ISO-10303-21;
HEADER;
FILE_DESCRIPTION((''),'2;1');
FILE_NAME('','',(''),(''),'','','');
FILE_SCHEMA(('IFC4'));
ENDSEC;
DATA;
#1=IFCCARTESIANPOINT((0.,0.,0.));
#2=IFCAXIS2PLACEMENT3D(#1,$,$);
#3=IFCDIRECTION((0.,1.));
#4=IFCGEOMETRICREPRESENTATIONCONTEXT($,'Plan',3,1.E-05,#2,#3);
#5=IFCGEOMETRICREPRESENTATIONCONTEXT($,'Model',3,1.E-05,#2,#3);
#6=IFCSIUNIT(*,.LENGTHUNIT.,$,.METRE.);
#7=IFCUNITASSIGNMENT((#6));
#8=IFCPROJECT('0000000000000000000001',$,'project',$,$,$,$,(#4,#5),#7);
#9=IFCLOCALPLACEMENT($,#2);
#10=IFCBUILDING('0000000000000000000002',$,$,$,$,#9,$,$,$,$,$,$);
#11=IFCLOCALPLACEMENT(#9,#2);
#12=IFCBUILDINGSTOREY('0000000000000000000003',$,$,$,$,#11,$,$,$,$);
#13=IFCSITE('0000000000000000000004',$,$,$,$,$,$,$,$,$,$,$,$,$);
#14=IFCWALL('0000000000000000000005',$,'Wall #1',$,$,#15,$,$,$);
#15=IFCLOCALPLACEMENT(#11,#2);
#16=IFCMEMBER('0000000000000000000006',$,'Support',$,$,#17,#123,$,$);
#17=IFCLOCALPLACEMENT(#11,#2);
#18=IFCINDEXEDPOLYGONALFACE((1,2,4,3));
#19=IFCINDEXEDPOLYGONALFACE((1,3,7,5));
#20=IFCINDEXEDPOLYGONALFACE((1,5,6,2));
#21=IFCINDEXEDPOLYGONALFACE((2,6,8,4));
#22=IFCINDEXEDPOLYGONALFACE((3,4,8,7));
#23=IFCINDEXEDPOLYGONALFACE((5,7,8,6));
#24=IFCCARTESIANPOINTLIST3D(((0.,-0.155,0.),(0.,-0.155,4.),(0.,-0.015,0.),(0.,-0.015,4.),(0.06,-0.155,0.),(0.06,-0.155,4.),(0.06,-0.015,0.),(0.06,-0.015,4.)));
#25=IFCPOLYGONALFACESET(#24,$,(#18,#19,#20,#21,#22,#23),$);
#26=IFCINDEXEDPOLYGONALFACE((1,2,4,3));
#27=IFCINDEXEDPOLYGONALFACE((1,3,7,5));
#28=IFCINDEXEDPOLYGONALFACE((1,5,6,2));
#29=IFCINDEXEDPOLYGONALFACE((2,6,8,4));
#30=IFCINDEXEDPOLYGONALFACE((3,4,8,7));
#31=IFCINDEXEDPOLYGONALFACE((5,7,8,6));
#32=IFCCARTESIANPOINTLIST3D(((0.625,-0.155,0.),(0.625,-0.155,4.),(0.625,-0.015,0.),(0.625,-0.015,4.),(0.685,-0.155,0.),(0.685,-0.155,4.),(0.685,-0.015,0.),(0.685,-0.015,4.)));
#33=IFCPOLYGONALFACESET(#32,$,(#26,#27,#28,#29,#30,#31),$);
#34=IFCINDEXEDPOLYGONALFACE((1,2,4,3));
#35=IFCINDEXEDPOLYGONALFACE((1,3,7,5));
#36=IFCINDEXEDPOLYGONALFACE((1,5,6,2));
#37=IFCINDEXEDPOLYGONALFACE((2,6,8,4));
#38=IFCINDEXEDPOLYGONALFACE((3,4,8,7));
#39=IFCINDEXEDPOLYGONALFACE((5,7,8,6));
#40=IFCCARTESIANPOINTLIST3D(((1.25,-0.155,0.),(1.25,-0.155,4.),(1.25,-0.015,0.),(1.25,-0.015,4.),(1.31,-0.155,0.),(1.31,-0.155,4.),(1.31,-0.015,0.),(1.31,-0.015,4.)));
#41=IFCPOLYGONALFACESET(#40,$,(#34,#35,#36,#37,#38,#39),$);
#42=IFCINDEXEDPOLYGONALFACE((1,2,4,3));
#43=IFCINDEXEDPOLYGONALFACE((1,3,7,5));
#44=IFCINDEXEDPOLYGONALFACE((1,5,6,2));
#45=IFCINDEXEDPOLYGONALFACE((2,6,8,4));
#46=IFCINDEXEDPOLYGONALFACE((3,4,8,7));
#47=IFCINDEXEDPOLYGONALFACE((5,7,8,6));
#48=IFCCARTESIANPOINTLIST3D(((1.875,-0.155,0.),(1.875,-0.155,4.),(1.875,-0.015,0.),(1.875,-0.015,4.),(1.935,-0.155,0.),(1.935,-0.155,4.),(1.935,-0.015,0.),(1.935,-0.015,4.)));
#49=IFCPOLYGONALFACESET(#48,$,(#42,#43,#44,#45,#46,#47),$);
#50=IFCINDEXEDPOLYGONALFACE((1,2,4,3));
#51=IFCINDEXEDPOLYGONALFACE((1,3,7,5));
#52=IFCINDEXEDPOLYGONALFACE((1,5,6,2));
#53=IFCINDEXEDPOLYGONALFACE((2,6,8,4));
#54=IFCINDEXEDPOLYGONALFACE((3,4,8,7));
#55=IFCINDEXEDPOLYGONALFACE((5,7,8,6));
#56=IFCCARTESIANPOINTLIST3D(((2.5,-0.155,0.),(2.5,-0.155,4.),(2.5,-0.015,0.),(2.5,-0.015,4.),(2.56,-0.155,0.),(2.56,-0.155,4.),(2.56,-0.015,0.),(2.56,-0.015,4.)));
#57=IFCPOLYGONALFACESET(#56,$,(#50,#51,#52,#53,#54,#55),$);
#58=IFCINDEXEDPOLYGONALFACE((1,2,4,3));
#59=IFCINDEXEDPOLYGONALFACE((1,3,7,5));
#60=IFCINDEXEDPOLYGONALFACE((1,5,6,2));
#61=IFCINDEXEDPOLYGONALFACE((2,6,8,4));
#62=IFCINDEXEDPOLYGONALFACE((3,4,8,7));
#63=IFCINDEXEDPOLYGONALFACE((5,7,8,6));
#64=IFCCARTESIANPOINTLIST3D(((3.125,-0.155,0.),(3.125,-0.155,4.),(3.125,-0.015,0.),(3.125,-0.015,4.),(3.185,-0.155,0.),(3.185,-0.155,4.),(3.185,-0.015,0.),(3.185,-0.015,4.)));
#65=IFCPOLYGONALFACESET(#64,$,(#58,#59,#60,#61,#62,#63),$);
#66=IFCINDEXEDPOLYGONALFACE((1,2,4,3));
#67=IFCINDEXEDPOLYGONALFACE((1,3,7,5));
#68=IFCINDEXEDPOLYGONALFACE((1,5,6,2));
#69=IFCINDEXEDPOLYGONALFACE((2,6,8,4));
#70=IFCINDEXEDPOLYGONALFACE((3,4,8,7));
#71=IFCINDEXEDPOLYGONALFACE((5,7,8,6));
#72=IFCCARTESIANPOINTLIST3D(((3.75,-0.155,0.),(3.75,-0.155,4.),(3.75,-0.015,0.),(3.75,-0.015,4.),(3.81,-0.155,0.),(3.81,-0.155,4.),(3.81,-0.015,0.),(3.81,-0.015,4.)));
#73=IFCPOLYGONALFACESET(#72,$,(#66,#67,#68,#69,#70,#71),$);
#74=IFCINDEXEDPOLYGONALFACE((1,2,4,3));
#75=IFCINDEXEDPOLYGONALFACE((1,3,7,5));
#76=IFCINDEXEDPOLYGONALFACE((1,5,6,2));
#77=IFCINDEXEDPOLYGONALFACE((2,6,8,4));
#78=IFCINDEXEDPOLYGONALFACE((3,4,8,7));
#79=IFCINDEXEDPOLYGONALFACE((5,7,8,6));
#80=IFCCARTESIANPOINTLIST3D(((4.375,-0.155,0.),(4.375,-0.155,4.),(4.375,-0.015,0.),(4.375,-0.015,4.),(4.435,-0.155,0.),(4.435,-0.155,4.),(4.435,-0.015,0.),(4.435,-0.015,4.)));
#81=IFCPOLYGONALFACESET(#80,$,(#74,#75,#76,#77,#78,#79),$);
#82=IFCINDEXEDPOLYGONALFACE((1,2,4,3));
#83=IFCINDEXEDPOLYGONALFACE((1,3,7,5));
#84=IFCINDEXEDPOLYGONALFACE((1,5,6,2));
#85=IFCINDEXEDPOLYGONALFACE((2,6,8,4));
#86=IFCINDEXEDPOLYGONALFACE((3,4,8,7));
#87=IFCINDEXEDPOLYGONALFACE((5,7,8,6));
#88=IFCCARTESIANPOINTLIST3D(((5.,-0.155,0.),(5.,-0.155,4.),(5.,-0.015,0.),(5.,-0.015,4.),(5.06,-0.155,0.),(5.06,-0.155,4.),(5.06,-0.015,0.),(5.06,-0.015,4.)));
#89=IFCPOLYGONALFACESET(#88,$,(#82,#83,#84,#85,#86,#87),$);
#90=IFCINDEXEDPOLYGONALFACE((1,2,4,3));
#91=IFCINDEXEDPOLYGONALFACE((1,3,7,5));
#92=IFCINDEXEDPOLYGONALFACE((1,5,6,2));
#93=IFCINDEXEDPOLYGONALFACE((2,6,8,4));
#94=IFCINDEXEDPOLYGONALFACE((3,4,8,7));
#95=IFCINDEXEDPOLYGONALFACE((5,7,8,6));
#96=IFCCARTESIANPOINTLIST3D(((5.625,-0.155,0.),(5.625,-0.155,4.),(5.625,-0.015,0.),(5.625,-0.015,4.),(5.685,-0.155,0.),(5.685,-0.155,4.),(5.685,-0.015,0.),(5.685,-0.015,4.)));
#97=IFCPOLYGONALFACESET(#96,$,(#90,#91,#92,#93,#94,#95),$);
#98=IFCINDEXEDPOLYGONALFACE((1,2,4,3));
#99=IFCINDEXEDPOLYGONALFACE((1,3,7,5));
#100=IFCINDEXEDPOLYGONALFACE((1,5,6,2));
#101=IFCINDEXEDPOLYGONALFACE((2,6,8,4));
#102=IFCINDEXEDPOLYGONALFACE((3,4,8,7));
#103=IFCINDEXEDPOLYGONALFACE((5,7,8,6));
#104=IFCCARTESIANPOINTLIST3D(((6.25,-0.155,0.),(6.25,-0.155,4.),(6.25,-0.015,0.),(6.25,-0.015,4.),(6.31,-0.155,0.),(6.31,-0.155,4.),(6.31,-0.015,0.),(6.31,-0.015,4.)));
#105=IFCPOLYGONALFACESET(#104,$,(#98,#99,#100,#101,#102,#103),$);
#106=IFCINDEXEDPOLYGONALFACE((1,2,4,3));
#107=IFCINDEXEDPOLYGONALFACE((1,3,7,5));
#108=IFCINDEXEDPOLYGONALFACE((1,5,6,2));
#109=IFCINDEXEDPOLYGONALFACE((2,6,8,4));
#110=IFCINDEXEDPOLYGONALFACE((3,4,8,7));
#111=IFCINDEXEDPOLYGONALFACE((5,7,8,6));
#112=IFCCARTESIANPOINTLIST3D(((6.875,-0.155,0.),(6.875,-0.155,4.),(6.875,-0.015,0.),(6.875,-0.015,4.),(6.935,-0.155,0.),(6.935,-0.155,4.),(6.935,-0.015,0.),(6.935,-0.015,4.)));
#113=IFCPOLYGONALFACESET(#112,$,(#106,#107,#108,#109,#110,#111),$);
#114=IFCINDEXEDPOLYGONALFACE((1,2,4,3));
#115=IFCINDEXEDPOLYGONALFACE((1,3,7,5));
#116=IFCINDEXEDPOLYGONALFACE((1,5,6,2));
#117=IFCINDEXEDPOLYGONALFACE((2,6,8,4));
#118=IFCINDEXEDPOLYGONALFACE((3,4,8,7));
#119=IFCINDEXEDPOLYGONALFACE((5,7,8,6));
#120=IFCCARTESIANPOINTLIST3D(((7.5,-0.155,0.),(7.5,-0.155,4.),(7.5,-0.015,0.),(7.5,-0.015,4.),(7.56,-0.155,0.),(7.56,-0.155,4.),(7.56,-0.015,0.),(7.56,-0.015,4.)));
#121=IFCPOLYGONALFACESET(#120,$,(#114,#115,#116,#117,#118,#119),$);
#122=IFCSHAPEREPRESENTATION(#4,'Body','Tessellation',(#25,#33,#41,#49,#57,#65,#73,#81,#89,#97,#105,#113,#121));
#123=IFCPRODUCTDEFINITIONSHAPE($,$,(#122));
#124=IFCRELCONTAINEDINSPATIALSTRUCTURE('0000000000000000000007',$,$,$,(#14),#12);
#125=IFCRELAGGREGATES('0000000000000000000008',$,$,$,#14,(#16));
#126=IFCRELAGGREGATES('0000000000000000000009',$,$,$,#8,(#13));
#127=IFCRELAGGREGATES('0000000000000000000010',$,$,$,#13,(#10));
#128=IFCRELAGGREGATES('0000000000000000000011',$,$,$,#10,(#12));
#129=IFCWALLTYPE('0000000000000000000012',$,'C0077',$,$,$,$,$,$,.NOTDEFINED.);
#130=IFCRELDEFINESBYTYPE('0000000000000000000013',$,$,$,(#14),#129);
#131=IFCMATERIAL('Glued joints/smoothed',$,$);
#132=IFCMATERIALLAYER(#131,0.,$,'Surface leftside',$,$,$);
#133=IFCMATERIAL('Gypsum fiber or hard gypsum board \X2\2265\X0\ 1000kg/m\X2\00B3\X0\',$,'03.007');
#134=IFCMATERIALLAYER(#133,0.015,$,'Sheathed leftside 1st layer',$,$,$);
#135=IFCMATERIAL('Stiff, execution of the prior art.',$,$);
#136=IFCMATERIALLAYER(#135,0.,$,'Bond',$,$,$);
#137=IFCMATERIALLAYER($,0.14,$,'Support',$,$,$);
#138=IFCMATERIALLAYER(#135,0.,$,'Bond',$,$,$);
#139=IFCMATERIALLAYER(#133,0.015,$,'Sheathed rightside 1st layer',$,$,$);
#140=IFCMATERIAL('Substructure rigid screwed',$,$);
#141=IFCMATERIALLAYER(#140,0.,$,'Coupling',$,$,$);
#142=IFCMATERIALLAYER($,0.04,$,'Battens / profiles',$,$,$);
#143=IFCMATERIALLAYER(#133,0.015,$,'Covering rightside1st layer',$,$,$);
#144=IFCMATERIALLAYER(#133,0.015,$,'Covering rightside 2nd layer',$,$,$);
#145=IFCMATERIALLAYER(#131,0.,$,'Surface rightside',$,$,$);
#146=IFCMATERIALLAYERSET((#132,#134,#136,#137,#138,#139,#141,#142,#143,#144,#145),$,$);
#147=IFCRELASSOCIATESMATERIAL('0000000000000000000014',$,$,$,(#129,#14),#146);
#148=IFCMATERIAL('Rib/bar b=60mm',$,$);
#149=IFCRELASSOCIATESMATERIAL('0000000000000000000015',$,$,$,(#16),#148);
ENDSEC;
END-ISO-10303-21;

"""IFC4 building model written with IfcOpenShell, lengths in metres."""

from ifc_helpers import new_model, si_unit, direction, frame, frame_2d, origin, place, context, project, spatial, rectangle, extrude, material, layer, layer_set, type_object, element, aggregate, save


model = new_model("IFC4")

# Units and contexts
plan_context = context("Plan", 3, precision=1e-05, world=origin(), true_north=direction((0.0, 1.0)))
model_context = context("Model", 3, precision=1e-05, world=origin(), true_north=direction((0.0, 1.0)))
ifc_project = project(units=[si_unit("LENGTHUNIT", "METRE")], contexts=[plan_context, model_context])

# Site, building, storey
site = spatial("IfcSite", under=ifc_project)
building_placement = place(None, origin())
building = spatial("IfcBuilding", under=site, at=building_placement)
storey_placement = place(building_placement, origin())
storey = spatial("IfcBuildingStorey", under=building, at=storey_placement)

# Wall, member
ifc_material_1 = material(Name="Glued joints/smoothed")
ifc_layer_1 = layer(ifc_material_1, 0.0, Name="Surface leftside")
ifc_material_2 = material(Name="Gypsum fiber or hard gypsum board ≥ 1000kg/m³", Category="03.007")
ifc_layer_2 = layer(ifc_material_2, 0.015, Name="Sheathed leftside 1st layer")
ifc_material_3 = material(Name="Stiff, execution of the prior art.")
ifc_layer_3 = layer(ifc_material_3, 0.0, Name="Bond")
ifc_layer_4 = layer(None, 0.14, Name="Support")
ifc_layer_5 = layer(ifc_material_3, 0.0, Name="Bond")
ifc_layer_6 = layer(ifc_material_2, 0.015, Name="Sheathed rightside 1st layer")
ifc_material_4 = material(Name="Substructure rigid screwed")
ifc_layer_7 = layer(ifc_material_4, 0.0, Name="Coupling")
ifc_layer_8 = layer(None, 0.04, Name="Battens / profiles")
ifc_layer_9 = layer(ifc_material_2, 0.015, Name="Covering rightside1st layer")
ifc_layer_10 = layer(ifc_material_2, 0.015, Name="Covering rightside 2nd layer")
ifc_layer_11 = layer(ifc_material_1, 0.0, Name="Surface rightside")
ifc_layer_set = layer_set([ifc_layer_1, ifc_layer_2, ifc_layer_3, ifc_layer_4, ifc_layer_5, ifc_layer_6, ifc_layer_7, ifc_layer_8, ifc_layer_9, ifc_layer_10, ifc_layer_11])
wall_type = type_object("IfcWallType", Name="C0077", PredefinedType="NOTDEFINED", material=ifc_layer_set)
wall_placement = place(None, frame((0.0, 0.0, 0.0), z_axis=(0.0, -1.0, 0.0), x_axis=(1.0, 0.0, 0.0)))
wall = element("IfcWall", 1, at=wall_placement, inside=storey, type_object=wall_type, material=ifc_layer_set, Name="Wall #1")
ifc_material_5 = material(Name="Rib/bar b=60mm")
member_1_placement = place(wall_placement, origin())
member_1 = element("IfcMember", 2, at=member_1_placement, material=ifc_material_5, Name="Support", context=plan_context, shape_type="SweptSolid", body=[
    extrude(rectangle(XDim=0.06, YDim=0.14, at=frame_2d((0.03, 0.07), x_axis=(1.0, 0.0))), frame((0.0, 4.0, 0.015), z_axis=(0.0, -1.0, 0.0), x_axis=(1.0, 0.0, 0.0)), (0.0, 0.0, 1.0), 4.0),
    extrude(rectangle(XDim=0.06, YDim=0.14, at=frame_2d((0.03, 0.07), x_axis=(1.0, 0.0))), frame((0.625, 4.0, 0.015), z_axis=(0.0, -1.0, 0.0), x_axis=(1.0, 0.0, 0.0)), (0.0, 0.0, 1.0), 4.0),
    extrude(rectangle(XDim=0.06, YDim=0.14, at=frame_2d((0.03, 0.07), x_axis=(1.0, 0.0))), frame((1.25, 4.0, 0.015), z_axis=(0.0, -1.0, 0.0), x_axis=(1.0, 0.0, 0.0)), (0.0, 0.0, 1.0), 4.0),
    extrude(rectangle(XDim=0.06, YDim=0.14, at=frame_2d((0.03, 0.07), x_axis=(1.0, 0.0))), frame((1.875, 4.0, 0.015), z_axis=(0.0, -1.0, 0.0), x_axis=(1.0, 0.0, 0.0)), (0.0, 0.0, 1.0), 4.0),
    extrude(rectangle(XDim=0.06, YDim=0.14, at=frame_2d((0.03, 0.07), x_axis=(1.0, 0.0))), frame((2.5, 4.0, 0.015), z_axis=(0.0, -1.0, 0.0), x_axis=(1.0, 0.0, 0.0)), (0.0, 0.0, 1.0), 4.0),
    extrude(rectangle(XDim=0.06, YDim=0.14, at=frame_2d((0.03, 0.07), x_axis=(1.0, 0.0))), frame((3.125, 4.0, 0.015), z_axis=(0.0, -1.0, 0.0), x_axis=(1.0, 0.0, 0.0)), (0.0, 0.0, 1.0), 4.0),
    extrude(rectangle(XDim=0.06, YDim=0.14, at=frame_2d((0.03, 0.07), x_axis=(1.0, 0.0))), frame((3.75, 4.0, 0.015), z_axis=(0.0, -1.0, 0.0), x_axis=(1.0, 0.0, 0.0)), (0.0, 0.0, 1.0), 4.0),
    extrude(rectangle(XDim=0.06, YDim=0.14, at=frame_2d((0.03, 0.07), x_axis=(1.0, 0.0))), frame((4.375, 4.0, 0.015), z_axis=(0.0, -1.0, 0.0), x_axis=(1.0, 0.0, 0.0)), (0.0, 0.0, 1.0), 4.0),
    extrude(rectangle(XDim=0.06, YDim=0.14, at=frame_2d((0.03, 0.07), x_axis=(1.0, 0.0))), frame((5.0, 4.0, 0.015), z_axis=(0.0, -1.0, 0.0), x_axis=(1.0, 0.0, 0.0)), (0.0, 0.0, 1.0), 4.0),
    extrude(rectangle(XDim=0.06, YDim=0.14, at=frame_2d((0.03, 0.07), x_axis=(1.0, 0.0))), frame((5.625, 4.0, 0.015), z_axis=(0.0, -1.0, 0.0), x_axis=(1.0, 0.0, 0.0)), (0.0, 0.0, 1.0), 4.0),
    extrude(rectangle(XDim=0.06, YDim=0.14, at=frame_2d((0.03, 0.07), x_axis=(1.0, 0.0))), frame((6.25, 4.0, 0.015), z_axis=(0.0, -1.0, 0.0), x_axis=(1.0, 0.0, 0.0)), (0.0, 0.0, 1.0), 4.0),
    extrude(rectangle(XDim=0.06, YDim=0.14, at=frame_2d((0.03, 0.07), x_axis=(1.0, 0.0))), frame((6.875, 4.0, 0.015), z_axis=(0.0, -1.0, 0.0), x_axis=(1.0, 0.0, 0.0)), (0.0, 0.0, 1.0), 4.0),
    extrude(rectangle(XDim=0.06, YDim=0.14, at=frame_2d((0.03, 0.07), x_axis=(1.0, 0.0))), frame((7.5, 4.0, 0.015), z_axis=(0.0, -1.0, 0.0), x_axis=(1.0, 0.0, 0.0)), (0.0, 0.0, 1.0), 4.0),
])
aggregate(wall, [member_1])

save(model, "model.ifc")
